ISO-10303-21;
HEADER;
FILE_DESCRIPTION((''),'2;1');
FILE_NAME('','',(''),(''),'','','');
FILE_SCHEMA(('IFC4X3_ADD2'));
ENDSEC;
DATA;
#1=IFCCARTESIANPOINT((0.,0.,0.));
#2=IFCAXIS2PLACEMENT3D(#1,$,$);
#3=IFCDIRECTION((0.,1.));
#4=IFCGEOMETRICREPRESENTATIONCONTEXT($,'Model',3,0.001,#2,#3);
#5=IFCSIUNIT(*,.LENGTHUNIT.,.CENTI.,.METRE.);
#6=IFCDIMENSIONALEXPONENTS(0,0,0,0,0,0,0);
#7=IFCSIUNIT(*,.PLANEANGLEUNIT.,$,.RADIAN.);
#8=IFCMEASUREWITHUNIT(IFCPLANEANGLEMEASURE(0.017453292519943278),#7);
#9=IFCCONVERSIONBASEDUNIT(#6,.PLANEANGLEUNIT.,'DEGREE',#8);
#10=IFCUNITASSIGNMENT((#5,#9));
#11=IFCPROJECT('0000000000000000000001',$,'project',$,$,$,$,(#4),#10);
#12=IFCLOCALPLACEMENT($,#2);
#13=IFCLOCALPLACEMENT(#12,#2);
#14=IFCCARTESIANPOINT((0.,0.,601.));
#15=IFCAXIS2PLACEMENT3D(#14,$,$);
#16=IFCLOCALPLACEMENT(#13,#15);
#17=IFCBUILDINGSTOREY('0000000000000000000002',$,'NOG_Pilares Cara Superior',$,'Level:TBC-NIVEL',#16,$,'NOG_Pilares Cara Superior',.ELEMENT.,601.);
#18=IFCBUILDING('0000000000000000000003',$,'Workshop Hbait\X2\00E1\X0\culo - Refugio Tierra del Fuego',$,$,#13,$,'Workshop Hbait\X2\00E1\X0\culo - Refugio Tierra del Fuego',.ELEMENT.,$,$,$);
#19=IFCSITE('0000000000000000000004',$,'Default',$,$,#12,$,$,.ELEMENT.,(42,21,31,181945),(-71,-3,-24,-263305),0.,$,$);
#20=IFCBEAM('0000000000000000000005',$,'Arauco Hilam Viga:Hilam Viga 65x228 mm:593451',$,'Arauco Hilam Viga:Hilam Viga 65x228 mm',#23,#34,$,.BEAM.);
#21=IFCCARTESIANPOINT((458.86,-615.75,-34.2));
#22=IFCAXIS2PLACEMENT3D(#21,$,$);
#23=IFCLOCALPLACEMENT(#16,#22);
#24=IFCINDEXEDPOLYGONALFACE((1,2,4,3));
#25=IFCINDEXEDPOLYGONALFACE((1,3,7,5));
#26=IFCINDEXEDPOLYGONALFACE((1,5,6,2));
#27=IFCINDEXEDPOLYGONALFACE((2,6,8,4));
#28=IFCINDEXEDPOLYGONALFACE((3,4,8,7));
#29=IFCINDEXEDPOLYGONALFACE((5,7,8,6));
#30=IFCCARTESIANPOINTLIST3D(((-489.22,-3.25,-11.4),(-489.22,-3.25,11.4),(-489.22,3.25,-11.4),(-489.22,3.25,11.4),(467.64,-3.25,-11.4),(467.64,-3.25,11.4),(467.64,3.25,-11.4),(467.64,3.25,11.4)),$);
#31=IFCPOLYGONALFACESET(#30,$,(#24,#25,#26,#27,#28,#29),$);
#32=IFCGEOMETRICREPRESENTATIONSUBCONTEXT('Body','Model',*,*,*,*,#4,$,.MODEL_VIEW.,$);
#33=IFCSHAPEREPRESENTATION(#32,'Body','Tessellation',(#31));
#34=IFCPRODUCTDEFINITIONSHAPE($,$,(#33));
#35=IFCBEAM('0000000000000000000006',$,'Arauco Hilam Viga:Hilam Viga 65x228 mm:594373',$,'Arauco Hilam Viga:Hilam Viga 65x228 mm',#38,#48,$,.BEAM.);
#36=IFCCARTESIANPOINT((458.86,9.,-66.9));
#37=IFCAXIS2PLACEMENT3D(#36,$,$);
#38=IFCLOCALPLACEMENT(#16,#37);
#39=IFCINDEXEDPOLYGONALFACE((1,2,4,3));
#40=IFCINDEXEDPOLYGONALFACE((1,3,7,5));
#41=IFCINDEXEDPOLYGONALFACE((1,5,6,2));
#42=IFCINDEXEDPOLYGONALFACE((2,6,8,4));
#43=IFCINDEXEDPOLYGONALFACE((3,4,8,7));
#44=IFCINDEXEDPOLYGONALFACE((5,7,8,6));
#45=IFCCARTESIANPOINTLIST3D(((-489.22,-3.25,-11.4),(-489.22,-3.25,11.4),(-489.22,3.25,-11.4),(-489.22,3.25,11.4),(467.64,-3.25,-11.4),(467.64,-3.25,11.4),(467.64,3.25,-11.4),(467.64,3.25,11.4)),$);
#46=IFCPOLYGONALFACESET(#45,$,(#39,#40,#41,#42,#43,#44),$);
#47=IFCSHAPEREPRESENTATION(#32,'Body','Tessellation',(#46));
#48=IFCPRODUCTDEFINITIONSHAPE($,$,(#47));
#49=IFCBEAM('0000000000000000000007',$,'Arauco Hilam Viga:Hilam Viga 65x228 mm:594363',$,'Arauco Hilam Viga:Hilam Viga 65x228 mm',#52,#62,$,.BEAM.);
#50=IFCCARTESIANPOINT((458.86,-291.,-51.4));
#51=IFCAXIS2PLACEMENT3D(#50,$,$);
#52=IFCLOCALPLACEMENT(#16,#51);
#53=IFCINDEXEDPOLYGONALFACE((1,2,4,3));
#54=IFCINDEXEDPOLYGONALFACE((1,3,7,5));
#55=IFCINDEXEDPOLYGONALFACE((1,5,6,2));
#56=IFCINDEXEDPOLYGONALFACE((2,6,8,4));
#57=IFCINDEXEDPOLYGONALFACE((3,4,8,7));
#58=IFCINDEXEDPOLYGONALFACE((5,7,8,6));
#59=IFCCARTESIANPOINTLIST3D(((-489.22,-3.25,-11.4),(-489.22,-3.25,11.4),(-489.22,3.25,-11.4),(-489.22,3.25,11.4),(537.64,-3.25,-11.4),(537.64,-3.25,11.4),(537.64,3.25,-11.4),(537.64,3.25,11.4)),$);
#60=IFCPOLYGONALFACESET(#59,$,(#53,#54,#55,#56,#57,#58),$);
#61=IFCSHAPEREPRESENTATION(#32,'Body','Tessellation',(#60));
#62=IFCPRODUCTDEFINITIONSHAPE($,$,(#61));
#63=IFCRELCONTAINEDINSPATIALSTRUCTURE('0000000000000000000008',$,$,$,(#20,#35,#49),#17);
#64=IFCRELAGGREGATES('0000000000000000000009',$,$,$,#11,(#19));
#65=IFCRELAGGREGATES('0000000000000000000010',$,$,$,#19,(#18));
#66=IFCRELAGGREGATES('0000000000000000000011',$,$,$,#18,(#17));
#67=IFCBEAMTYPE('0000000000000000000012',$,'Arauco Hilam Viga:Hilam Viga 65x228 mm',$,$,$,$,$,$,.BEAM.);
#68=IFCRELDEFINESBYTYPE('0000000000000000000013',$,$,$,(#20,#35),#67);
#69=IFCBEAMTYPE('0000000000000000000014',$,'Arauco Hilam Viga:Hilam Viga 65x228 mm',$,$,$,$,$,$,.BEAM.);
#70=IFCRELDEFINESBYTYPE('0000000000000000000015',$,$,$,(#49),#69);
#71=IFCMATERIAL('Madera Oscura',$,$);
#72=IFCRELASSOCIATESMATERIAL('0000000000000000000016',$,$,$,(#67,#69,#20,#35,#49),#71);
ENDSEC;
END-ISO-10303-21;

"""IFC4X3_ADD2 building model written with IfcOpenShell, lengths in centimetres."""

from ifc_helpers import new_model, entity, si_unit, converted_unit, direction, frame, origin, origin_2d_with_axis, place, context, subcontext, project, spatial, rectangle, extrude, source, transform, mapped, material, material_profile, profile_set, profile_usage, type_object, type_shapes, element, save


model = new_model("IFC4X3_ADD2")

# Units and contexts
model_context = context("Model", 3, precision=0.001, world=origin(), true_north=direction((0.0, 1.0)))
body_context = subcontext(model_context, "Body", "Model", "MODEL_VIEW")
ifc_project = project(units=[si_unit("LENGTHUNIT", "METRE", prefix="CENTI"), converted_unit("PLANEANGLEUNIT", "DEGREE", entity("IfcPlaneAngleMeasure", 0.017453292519943278), si_unit("PLANEANGLEUNIT", "RADIAN"), dimensions=[0, 0, 0, 0, 0, 0, 0])], contexts=[model_context])

# Site, building, storey
site_placement = place(None, origin())
site = spatial("IfcSite", under=ifc_project, at=site_placement, Name="Default", CompositionType="ELEMENT", RefLatitude=(42, 21, 31, 181945), RefLongitude=(-71, -3, -24, -263305), RefElevation=0.0)
building_placement = place(site_placement, origin())
building = spatial("IfcBuilding", under=site, at=building_placement, Name="Workshop Hbaitáculo - Refugio Tierra del Fuego", LongName="Workshop Hbaitáculo - Refugio Tierra del Fuego", CompositionType="ELEMENT")
storey_placement = place(building_placement, frame((0.0, 0.0, 601.0)))
storey = spatial("IfcBuildingStorey", under=building, at=storey_placement, Name="NOG_Pilares Cara Superior", ObjectType="Level:TBC-NIVEL", LongName="NOG_Pilares Cara Superior", CompositionType="ELEMENT", Elevation=601.0)

# Beams
ifc_material = material(Name="Madera Oscura")
ifc_material_profile = material_profile(ifc_material, rectangle(XDim=930.0, YDim=6.5, at=origin_2d_with_axis()), Name="Hilam Viga 65x228 mm")
ifc_profile_set = profile_set([ifc_material_profile], Name="Hilam Viga 65x228 mm")
ifc_profile_usage = profile_usage(ifc_profile_set, cardinal=8)
beam_type_1 = type_object("IfcBeamType", Name="Arauco Hilam Viga:Hilam Viga 65x228 mm", PredefinedType="BEAM", material=ifc_profile_set)
shared_shape_1 = source(origin(), body_context, "Body", "SweptSolid", [
    extrude(rectangle(XDim=6.5, YDim=956.86, at=origin_2d_with_axis()), frame((-10.79, 0.0, -11.4), z_axis=(0.0, 0.0, 1.0), x_axis=(0.0, 1.0, 0.0)), (0.0, 0.0, 1.0), 22.8),
])
type_shapes(beam_type_1, [shared_shape_1])
for number, where, name in (
    (1, (458.86, -615.75, -34.2), "Arauco Hilam Viga:Hilam Viga 65x228 mm:593451"),
    (2, (458.86, 9.0, -66.9), "Arauco Hilam Viga:Hilam Viga 65x228 mm:594373"),
):
    element("IfcBeam", number, at=place(storey_placement, frame(where)), inside=storey, type_object=beam_type_1, material=ifc_profile_usage, Name=name, ObjectType="Arauco Hilam Viga:Hilam Viga 65x228 mm", PredefinedType="BEAM", context=body_context, shape_type="MappedRepresentation", body=[
        mapped(shared_shape_1, transform((0.0, 0.0, 0.0), scale=1.0)),
    ])
beam_type_2 = type_object("IfcBeamType", Name="Arauco Hilam Viga:Hilam Viga 65x228 mm", PredefinedType="BEAM", material=ifc_profile_set)
shared_shape_2 = source(origin(), body_context, "Body", "SweptSolid", [
    extrude(rectangle(XDim=6.5, YDim=1026.86, at=origin_2d_with_axis()), frame((24.21, 0.0, -11.4), z_axis=(0.0, 0.0, 1.0), x_axis=(0.0, 1.0, 0.0)), (0.0, 0.0, 1.0), 22.8),
])
type_shapes(beam_type_2, [shared_shape_2])
beam_placement = place(storey_placement, frame((458.86, -291.0, -51.4)))
element("IfcBeam", 3, at=beam_placement, inside=storey, type_object=beam_type_2, material=ifc_profile_usage, Name="Arauco Hilam Viga:Hilam Viga 65x228 mm:594363", ObjectType="Arauco Hilam Viga:Hilam Viga 65x228 mm", PredefinedType="BEAM", context=body_context, shape_type="MappedRepresentation", body=[
    mapped(shared_shape_2, transform((0.0, 0.0, 0.0), scale=1.0)),
])

save(model, "model.ifc")
